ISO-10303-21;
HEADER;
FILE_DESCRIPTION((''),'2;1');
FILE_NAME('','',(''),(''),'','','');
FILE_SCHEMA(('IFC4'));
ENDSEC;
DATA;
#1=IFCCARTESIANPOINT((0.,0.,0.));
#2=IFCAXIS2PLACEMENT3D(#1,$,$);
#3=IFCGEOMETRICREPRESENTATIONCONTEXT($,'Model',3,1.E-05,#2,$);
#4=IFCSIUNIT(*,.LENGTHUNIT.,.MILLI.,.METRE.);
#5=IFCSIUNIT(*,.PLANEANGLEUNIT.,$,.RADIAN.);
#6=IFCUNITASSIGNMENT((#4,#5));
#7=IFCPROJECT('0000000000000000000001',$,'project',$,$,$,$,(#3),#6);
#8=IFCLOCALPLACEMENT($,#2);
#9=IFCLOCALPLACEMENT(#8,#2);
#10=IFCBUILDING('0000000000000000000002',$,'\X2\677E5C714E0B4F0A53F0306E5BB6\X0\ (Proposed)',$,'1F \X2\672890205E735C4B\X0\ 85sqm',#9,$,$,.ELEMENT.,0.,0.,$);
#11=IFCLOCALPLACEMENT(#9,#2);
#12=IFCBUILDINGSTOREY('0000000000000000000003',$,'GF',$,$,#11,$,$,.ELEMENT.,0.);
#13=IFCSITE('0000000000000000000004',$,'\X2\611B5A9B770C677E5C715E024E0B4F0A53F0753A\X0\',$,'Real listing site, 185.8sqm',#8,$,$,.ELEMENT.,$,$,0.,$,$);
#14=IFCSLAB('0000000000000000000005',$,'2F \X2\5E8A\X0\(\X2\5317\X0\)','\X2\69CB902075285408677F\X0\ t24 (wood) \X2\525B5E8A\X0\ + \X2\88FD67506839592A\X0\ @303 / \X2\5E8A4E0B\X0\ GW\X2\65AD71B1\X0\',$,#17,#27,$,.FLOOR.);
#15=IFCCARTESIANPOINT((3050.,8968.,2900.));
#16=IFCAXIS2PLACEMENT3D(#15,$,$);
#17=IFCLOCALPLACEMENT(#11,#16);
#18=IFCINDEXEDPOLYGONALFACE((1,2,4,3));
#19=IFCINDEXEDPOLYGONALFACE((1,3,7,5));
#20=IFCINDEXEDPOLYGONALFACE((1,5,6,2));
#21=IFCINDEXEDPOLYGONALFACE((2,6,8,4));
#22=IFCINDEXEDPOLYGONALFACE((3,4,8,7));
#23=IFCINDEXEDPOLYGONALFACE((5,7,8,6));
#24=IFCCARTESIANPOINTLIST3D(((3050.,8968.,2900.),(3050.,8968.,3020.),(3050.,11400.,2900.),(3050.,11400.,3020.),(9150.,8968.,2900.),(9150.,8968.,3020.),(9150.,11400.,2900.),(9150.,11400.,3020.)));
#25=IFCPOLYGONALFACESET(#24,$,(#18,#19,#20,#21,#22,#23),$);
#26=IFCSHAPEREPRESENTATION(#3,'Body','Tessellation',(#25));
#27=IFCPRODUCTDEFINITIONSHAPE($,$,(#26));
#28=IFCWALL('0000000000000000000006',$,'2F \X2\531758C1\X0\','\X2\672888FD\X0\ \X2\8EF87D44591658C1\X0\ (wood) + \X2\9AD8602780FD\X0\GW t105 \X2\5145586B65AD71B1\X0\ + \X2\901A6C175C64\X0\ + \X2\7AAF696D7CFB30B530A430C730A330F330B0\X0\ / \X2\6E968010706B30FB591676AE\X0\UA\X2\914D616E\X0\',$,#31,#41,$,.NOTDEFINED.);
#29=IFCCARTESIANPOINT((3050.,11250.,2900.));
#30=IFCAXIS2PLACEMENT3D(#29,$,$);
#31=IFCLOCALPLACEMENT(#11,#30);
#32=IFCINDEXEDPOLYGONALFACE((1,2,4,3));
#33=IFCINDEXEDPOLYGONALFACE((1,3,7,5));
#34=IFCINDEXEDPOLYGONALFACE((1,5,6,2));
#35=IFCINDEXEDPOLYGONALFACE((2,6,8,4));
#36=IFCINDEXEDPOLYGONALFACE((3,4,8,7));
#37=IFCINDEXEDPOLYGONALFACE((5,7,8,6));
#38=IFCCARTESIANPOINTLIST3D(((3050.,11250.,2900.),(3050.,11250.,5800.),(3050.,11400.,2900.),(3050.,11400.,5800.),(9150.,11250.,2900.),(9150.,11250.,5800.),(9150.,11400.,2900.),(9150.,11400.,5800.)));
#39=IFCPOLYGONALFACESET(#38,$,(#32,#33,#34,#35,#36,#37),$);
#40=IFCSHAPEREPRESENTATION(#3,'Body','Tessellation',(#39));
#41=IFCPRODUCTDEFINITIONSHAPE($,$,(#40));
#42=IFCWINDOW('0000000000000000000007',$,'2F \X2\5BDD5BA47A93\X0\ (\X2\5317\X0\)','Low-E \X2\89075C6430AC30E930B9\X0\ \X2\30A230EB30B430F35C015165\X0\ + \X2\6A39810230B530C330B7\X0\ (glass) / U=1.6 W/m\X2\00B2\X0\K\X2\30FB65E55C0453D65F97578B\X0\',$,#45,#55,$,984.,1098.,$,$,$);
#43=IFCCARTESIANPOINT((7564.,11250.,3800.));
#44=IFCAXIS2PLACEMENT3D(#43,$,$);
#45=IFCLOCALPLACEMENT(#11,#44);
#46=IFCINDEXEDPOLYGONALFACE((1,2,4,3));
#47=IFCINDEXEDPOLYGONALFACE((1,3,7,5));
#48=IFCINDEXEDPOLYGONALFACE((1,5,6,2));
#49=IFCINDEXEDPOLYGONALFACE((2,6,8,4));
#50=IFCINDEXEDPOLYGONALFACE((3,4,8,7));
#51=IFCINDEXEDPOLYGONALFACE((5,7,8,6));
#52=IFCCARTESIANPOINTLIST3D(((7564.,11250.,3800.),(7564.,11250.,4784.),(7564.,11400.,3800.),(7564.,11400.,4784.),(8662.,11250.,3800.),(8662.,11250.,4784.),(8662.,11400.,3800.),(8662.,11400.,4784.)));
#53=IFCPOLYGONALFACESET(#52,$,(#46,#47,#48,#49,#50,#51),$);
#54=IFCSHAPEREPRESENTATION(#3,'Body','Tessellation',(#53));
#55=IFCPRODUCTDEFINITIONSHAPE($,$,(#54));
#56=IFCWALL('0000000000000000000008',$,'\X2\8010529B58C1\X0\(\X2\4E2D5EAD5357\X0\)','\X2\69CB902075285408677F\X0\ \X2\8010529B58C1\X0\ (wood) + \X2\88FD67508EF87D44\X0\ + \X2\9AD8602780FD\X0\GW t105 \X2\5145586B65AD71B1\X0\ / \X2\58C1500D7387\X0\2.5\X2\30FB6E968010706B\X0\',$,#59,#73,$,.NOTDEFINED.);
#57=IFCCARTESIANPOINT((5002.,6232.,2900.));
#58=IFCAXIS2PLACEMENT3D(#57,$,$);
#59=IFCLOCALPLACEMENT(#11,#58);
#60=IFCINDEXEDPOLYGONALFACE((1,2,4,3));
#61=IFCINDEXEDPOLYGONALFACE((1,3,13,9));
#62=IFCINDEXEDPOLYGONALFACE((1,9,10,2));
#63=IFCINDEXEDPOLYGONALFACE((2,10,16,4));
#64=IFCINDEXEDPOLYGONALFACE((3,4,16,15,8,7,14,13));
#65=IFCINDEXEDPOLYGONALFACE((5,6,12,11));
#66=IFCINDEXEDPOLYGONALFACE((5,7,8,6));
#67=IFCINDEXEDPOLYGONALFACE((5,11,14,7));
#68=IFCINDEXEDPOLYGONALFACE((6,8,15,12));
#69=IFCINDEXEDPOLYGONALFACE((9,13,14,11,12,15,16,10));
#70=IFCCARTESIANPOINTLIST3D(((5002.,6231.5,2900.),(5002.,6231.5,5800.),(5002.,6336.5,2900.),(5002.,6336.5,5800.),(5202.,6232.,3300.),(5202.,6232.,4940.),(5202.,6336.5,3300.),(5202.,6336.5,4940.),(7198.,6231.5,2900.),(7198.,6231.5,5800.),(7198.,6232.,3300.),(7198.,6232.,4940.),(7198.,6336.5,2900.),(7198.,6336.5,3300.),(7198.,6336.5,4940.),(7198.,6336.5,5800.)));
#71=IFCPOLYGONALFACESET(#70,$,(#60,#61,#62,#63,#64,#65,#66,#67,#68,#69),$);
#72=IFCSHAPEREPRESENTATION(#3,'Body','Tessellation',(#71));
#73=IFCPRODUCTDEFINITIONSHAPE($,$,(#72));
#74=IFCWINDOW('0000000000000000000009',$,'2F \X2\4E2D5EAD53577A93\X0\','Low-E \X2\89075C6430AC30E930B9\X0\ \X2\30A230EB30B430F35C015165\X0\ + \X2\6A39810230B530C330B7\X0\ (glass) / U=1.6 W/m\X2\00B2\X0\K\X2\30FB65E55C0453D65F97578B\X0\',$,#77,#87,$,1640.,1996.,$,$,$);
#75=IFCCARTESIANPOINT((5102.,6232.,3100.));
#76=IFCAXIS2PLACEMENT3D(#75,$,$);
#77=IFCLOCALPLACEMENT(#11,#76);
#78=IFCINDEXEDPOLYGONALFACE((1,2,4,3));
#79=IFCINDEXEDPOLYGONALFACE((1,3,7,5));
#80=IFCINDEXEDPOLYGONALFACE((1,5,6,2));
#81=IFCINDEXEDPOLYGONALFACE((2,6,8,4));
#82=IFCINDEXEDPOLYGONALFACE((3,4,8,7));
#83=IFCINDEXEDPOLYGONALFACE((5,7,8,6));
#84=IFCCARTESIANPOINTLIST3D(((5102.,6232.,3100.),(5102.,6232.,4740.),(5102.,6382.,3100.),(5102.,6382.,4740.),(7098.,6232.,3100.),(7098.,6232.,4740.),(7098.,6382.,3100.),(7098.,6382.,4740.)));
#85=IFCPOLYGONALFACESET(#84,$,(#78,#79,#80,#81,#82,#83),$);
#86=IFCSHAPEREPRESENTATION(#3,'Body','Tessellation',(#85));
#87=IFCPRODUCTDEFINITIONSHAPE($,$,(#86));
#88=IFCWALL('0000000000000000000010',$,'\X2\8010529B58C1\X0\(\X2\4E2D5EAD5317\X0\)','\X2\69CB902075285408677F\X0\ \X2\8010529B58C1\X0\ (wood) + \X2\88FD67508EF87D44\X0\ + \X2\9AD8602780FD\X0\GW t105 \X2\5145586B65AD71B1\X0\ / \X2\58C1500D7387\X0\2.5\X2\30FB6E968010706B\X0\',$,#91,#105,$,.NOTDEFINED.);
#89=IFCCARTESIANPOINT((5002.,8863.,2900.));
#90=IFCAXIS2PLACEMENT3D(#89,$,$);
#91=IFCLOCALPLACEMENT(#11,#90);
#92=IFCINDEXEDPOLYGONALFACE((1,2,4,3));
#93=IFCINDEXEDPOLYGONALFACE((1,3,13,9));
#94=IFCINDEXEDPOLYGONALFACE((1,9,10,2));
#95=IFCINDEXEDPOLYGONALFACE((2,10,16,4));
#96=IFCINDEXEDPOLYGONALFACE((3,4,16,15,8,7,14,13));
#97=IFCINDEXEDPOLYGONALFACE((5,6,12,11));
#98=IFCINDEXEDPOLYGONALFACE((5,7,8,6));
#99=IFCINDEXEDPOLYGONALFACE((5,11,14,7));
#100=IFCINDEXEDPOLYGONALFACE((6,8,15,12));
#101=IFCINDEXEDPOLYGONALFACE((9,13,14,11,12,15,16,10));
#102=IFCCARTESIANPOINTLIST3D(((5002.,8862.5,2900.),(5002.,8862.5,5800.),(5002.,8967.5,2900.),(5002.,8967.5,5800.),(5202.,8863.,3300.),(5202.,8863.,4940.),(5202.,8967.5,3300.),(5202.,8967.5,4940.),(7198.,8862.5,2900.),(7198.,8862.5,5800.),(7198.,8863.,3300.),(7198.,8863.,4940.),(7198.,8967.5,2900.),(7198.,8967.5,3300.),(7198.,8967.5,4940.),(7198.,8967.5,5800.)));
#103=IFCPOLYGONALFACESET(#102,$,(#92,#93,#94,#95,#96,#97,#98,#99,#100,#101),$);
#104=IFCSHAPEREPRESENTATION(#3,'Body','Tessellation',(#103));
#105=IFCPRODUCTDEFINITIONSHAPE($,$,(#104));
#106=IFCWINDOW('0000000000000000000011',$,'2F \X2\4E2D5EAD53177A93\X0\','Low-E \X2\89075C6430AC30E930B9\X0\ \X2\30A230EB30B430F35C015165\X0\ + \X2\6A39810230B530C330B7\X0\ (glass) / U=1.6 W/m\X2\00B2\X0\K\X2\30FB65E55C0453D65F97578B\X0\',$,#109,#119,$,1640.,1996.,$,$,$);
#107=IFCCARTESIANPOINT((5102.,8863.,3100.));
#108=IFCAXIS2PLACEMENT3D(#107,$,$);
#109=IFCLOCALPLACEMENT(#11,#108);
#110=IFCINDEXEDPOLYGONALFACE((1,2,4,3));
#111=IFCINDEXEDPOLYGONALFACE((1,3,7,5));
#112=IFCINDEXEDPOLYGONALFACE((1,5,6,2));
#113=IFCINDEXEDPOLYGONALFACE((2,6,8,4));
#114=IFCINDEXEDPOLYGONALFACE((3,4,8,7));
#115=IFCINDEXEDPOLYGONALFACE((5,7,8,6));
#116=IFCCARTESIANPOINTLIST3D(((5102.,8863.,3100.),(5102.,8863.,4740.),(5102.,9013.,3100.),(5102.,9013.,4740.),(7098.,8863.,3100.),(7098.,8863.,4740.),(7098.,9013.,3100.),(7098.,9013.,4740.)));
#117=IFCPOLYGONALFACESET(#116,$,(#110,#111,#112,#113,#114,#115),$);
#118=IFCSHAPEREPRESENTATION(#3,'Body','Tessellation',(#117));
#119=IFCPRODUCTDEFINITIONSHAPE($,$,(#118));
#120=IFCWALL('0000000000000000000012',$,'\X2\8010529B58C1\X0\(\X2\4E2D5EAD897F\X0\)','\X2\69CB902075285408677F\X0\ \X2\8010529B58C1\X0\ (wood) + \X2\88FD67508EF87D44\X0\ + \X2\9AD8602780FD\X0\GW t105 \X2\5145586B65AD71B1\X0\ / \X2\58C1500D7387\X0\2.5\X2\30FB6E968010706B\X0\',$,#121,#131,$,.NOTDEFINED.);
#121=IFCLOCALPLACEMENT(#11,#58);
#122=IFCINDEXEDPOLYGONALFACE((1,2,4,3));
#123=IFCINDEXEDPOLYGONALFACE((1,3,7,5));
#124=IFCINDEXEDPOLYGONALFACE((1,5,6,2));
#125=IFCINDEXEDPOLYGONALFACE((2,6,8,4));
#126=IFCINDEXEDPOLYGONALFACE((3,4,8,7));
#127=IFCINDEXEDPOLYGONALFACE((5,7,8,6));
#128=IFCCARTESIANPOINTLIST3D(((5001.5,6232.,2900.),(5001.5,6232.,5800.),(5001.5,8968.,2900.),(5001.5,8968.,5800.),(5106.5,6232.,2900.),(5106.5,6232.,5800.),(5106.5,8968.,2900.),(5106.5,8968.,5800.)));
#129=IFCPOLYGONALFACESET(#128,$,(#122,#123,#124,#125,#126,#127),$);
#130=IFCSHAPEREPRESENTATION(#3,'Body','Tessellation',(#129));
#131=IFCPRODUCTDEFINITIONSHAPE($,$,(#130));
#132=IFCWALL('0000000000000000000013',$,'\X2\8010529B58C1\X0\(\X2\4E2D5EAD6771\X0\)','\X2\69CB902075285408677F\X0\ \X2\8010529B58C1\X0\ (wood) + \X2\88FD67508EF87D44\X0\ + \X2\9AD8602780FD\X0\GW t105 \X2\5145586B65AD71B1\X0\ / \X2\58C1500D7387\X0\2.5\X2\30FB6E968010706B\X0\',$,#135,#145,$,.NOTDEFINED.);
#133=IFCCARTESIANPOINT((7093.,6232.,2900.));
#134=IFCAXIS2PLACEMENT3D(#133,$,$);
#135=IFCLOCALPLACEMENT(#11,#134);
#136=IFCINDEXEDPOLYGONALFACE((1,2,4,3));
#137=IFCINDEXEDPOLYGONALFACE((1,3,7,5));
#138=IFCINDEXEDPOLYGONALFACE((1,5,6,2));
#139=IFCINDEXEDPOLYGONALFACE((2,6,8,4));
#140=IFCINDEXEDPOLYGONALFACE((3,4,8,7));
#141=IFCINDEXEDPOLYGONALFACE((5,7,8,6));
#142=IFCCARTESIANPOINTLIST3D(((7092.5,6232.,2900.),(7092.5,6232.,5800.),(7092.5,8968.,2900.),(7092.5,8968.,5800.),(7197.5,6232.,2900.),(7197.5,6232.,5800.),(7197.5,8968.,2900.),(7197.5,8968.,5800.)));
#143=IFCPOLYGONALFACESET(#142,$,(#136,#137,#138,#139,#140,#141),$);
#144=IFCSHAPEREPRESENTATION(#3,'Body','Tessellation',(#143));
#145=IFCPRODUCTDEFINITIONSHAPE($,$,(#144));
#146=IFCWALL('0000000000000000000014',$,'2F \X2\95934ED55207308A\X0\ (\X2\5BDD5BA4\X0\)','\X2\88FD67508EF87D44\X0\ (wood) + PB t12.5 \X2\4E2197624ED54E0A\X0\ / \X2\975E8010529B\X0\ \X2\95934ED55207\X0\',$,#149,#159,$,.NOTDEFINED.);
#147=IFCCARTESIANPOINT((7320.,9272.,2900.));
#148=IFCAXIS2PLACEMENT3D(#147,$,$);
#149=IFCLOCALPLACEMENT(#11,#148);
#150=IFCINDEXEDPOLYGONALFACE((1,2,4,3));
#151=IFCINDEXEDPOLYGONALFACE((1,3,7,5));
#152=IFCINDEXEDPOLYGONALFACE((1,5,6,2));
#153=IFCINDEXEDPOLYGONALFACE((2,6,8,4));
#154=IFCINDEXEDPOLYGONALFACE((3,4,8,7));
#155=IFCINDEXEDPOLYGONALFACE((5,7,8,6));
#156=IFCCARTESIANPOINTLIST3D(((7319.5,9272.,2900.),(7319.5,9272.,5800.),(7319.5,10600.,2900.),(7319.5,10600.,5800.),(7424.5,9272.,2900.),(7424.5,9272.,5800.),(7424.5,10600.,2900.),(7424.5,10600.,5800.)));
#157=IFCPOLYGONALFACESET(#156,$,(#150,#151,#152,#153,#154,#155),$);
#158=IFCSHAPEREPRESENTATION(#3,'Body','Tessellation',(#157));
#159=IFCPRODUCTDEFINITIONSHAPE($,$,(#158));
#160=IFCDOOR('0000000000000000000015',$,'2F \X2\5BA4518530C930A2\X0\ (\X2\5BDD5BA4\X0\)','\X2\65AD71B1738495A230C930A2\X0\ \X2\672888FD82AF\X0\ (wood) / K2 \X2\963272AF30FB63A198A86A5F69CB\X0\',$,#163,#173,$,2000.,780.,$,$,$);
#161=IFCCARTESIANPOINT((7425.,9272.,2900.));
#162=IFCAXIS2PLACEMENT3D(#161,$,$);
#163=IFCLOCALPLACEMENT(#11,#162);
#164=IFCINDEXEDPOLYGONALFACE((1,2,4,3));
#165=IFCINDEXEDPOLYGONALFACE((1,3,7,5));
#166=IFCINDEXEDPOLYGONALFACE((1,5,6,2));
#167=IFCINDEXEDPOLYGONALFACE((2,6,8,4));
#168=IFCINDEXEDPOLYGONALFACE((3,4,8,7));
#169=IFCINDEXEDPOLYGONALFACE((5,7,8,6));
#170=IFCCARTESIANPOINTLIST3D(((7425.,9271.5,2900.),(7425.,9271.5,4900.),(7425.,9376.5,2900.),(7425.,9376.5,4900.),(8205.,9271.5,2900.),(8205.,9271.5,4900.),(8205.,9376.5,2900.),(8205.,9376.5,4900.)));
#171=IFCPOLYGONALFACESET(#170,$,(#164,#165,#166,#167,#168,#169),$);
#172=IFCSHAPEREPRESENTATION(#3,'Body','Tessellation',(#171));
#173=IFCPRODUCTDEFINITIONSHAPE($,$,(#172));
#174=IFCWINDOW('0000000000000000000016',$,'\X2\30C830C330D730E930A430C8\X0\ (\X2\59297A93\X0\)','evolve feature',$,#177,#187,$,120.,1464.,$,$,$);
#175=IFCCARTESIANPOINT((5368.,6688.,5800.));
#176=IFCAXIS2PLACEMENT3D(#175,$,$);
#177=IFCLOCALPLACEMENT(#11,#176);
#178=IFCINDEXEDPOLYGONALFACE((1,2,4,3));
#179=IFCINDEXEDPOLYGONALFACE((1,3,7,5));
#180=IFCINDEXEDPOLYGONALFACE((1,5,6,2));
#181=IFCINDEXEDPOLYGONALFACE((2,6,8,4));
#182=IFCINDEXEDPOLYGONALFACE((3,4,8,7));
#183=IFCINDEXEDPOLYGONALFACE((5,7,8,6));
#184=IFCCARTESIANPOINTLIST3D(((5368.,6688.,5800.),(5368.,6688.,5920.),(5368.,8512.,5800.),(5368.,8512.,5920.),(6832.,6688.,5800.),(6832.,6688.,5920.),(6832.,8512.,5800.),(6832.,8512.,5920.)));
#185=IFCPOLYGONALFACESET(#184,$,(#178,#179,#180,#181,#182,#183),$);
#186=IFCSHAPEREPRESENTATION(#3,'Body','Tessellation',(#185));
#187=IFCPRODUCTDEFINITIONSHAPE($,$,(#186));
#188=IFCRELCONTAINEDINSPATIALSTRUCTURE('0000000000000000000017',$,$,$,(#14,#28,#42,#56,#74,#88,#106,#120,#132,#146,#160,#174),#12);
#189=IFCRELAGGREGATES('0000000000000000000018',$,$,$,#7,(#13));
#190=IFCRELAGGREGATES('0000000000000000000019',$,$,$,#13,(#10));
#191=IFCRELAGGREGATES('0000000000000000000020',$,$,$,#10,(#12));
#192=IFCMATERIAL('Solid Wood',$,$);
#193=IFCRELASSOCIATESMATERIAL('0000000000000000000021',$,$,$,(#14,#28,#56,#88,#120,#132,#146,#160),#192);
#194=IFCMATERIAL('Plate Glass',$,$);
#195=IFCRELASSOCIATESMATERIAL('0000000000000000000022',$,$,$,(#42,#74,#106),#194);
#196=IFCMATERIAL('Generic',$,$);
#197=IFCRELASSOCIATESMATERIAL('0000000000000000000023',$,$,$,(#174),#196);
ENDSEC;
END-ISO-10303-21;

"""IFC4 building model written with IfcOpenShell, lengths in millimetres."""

from ifc_helpers import new_model, si_unit, frame, frame_2d, origin, place, context, project, spatial, rectangle, extrude, material, element, fill, save


model = new_model("IFC4")

# Units and contexts
model_context = context("Model", 3, precision=1e-05, world=origin())
ifc_project = project(units=[si_unit("LENGTHUNIT", "METRE", prefix="MILLI"), si_unit("PLANEANGLEUNIT", "RADIAN")], contexts=[model_context])

# Site, building, storey
site_placement = place(None, origin())
site = spatial("IfcSite", under=ifc_project, at=site_placement, Name="愛媛県松山市下伊台町", ObjectType="Real listing site, 185.8sqm", CompositionType="ELEMENT", RefElevation=0.0)
building_placement = place(site_placement, origin())
building = spatial("IfcBuilding", under=site, at=building_placement, Name="松山下伊台の家 (Proposed)", ObjectType="1F 木造平屋 85sqm", CompositionType="ELEMENT", ElevationOfRefHeight=0.0, ElevationOfTerrain=0.0)
storey_placement = place(building_placement, origin())
storey = spatial("IfcBuildingStorey", under=building, at=storey_placement, Name="GF", CompositionType="ELEMENT", Elevation=0.0)

# Slab
ifc_material_1 = material(Name="Solid Wood")
slab_placement = place(storey_placement, frame((3050.0, 8968.0, 2900.0)))
element("IfcSlab", 1, at=slab_placement, inside=storey, material=ifc_material_1, Name="2F 床(北)", Description="構造用合板 t24 (wood) 剛床 + 製材根太 @303 / 床下 GW断熱", PredefinedType="FLOOR", context=model_context, shape_type="SweptSolid", body=[
    extrude(rectangle(XDim=6100.0, YDim=2432.0, at=frame_2d((3050.0, 1216.0))), frame((3050.0, 8968.0, 2900.0)), (0.0, 0.0, 1.0), 120.0),
])

# Walls, openings, windows
wall_1_placement = place(storey_placement, frame((3050.0, 11250.0, 2900.0)))
wall_1 = element("IfcWall", 2, at=wall_1_placement, inside=storey, material=ifc_material_1, Name="2F 北壁", Description="木製 軸組外壁 (wood) + 高性能GW t105 充填断熱 + 通気層 + 窯業系サイディング / 準耐火・外皮UA配慮", PredefinedType="NOTDEFINED", context=model_context, shape_type="SweptSolid", body=[
    extrude(rectangle(XDim=6100.0, YDim=150.0, at=frame_2d((3050.0, 75.0))), frame((3050.0, 11250.0, 2900.0)), (0.0, 0.0, 1.0), 2900.0),
])
opening_1_placement = place(storey_placement, frame((7564.0, 11250.0, 3800.0)))
opening_1 = element("IfcOpeningElement", 3, at=opening_1_placement, cuts=wall_1, PredefinedType="NOTDEFINED", context=model_context, shape_type="SweptSolid", body=[
    extrude(rectangle(XDim=1098.0, YDim=150.0, at=frame_2d((549.0, 75.0))), frame((7564.0, 11250.0, 3800.0)), (0.0, 0.0, 1.0), 984.0),
])
ifc_material_2 = material(Name="Plate Glass")
window_1_placement = place(storey_placement, frame((7564.0, 11250.0, 3800.0)))
window_1 = element("IfcWindow", 4, at=window_1_placement, inside=storey, material=ifc_material_2, Name="2F 寝室窓 (北)", Description="Low-E 複層ガラス アルゴン封入 + 樹脂サッシ (glass) / U=1.6 W/m²K・日射取得型", OverallHeight=984.0, OverallWidth=1098.0, context=model_context, shape_type="SweptSolid", body=[
    extrude(rectangle(XDim=1098.0, YDim=150.0, at=frame_2d((549.0, 75.0))), frame((7564.0, 11250.0, 3800.0)), (0.0, 0.0, 1.0), 984.0),
])
fill(opening_1, window_1)
wall_2_placement = place(storey_placement, frame((5002.0, 6232.0, 2900.0)))
wall_2 = element("IfcWall", 5, at=wall_2_placement, inside=storey, material=ifc_material_1, Name="耐力壁(中庭南)", Description="構造用合板 耐力壁 (wood) + 製材軸組 + 高性能GW t105 充填断熱 / 壁倍率2.5・準耐火", PredefinedType="NOTDEFINED", context=model_context, shape_type="SweptSolid", body=[
    extrude(rectangle(XDim=2196.0, YDim=105.0, at=frame_2d((1098.0, 52.0))), frame((5002.0, 6232.0, 2900.0)), (0.0, 0.0, 1.0), 2900.0),
])
opening_2_placement = place(storey_placement, frame((5102.0, 6232.0, 3100.0)))
opening_2 = element("IfcOpeningElement", 6, at=opening_2_placement, cuts=wall_2, PredefinedType="NOTDEFINED", context=model_context, shape_type="SweptSolid", body=[
    extrude(rectangle(XDim=1996.0, YDim=150.0, at=frame_2d((998.0, 75.0))), frame((5102.0, 6232.0, 3100.0)), (0.0, 0.0, 1.0), 1640.0),
])
window_2_placement = place(storey_placement, frame((5102.0, 6232.0, 3100.0)))
window_2 = element("IfcWindow", 7, at=window_2_placement, inside=storey, material=ifc_material_2, Name="2F 中庭南窓", Description="Low-E 複層ガラス アルゴン封入 + 樹脂サッシ (glass) / U=1.6 W/m²K・日射取得型", OverallHeight=1640.0, OverallWidth=1996.0, context=model_context, shape_type="SweptSolid", body=[
    extrude(rectangle(XDim=1996.0, YDim=150.0, at=frame_2d((998.0, 75.0))), frame((5102.0, 6232.0, 3100.0)), (0.0, 0.0, 1.0), 1640.0),
])
fill(opening_2, window_2)
wall_3_placement = place(storey_placement, frame((5002.0, 8863.0, 2900.0)))
wall_3 = element("IfcWall", 8, at=wall_3_placement, inside=storey, material=ifc_material_1, Name="耐力壁(中庭北)", Description="構造用合板 耐力壁 (wood) + 製材軸組 + 高性能GW t105 充填断熱 / 壁倍率2.5・準耐火", PredefinedType="NOTDEFINED", context=model_context, shape_type="SweptSolid", body=[
    extrude(rectangle(XDim=2196.0, YDim=105.0, at=frame_2d((1098.0, 52.0))), frame((5002.0, 8863.0, 2900.0)), (0.0, 0.0, 1.0), 2900.0),
])
opening_3_placement = place(storey_placement, frame((5102.0, 8863.0, 3100.0)))
opening_3 = element("IfcOpeningElement", 9, at=opening_3_placement, cuts=wall_3, PredefinedType="NOTDEFINED", context=model_context, shape_type="SweptSolid", body=[
    extrude(rectangle(XDim=1996.0, YDim=150.0, at=frame_2d((998.0, 75.0))), frame((5102.0, 8863.0, 3100.0)), (0.0, 0.0, 1.0), 1640.0),
])
window_3_placement = place(storey_placement, frame((5102.0, 8863.0, 3100.0)))
window_3 = element("IfcWindow", 10, at=window_3_placement, inside=storey, material=ifc_material_2, Name="2F 中庭北窓", Description="Low-E 複層ガラス アルゴン封入 + 樹脂サッシ (glass) / U=1.6 W/m²K・日射取得型", OverallHeight=1640.0, OverallWidth=1996.0, context=model_context, shape_type="SweptSolid", body=[
    extrude(rectangle(XDim=1996.0, YDim=150.0, at=frame_2d((998.0, 75.0))), frame((5102.0, 8863.0, 3100.0)), (0.0, 0.0, 1.0), 1640.0),
])
fill(opening_3, window_3)

# Walls
wall_4_placement = place(storey_placement, frame((5002.0, 6232.0, 2900.0)))
element("IfcWall", 11, at=wall_4_placement, inside=storey, material=ifc_material_1, Name="耐力壁(中庭西)", Description="構造用合板 耐力壁 (wood) + 製材軸組 + 高性能GW t105 充填断熱 / 壁倍率2.5・準耐火", PredefinedType="NOTDEFINED", context=model_context, shape_type="SweptSolid", body=[
    extrude(rectangle(XDim=105.0, YDim=2736.0, at=frame_2d((52.0, 1368.0))), frame((5002.0, 6232.0, 2900.0)), (0.0, 0.0, 1.0), 2900.0),
])
wall_5_placement = place(storey_placement, frame((7093.0, 6232.0, 2900.0)))
element("IfcWall", 12, at=wall_5_placement, inside=storey, material=ifc_material_1, Name="耐力壁(中庭東)", Description="構造用合板 耐力壁 (wood) + 製材軸組 + 高性能GW t105 充填断熱 / 壁倍率2.5・準耐火", PredefinedType="NOTDEFINED", context=model_context, shape_type="SweptSolid", body=[
    extrude(rectangle(XDim=105.0, YDim=2736.0, at=frame_2d((52.0, 1368.0))), frame((7093.0, 6232.0, 2900.0)), (0.0, 0.0, 1.0), 2900.0),
])
wall_6_placement = place(storey_placement, frame((7320.0, 9272.0, 2900.0)))
element("IfcWall", 13, at=wall_6_placement, inside=storey, material=ifc_material_1, Name="2F 間仕切り (寝室)", Description="製材軸組 (wood) + PB t12.5 両面仕上 / 非耐力 間仕切", PredefinedType="NOTDEFINED", context=model_context, shape_type="SweptSolid", body=[
    extrude(rectangle(XDim=105.0, YDim=1328.0, at=frame_2d((52.0, 664.0))), frame((7320.0, 9272.0, 2900.0)), (0.0, 0.0, 1.0), 2900.0),
])

# Door
door_placement = place(storey_placement, frame((7425.0, 9272.0, 2900.0)))
element("IfcDoor", 14, at=door_placement, inside=storey, material=ifc_material_1, Name="2F 室内ドア (寝室)", Description="断熱玄関ドア 木製芯 (wood) / K2 防犯・採風機構", OverallHeight=2000.0, OverallWidth=780.0, context=model_context, shape_type="SweptSolid", body=[
    extrude(rectangle(XDim=780.0, YDim=105.0, at=frame_2d((390.0, 52.0))), frame((7425.0, 9272.0, 2900.0)), (0.0, 0.0, 1.0), 2000.0),
])

# Window
ifc_material_3 = material(Name="Generic")
window_4_placement = place(storey_placement, frame((5368.0, 6688.0, 5800.0)))
element("IfcWindow", 15, at=window_4_placement, inside=storey, material=ifc_material_3, Name="トップライト (天窓)", Description="evolve feature", OverallHeight=120.0, OverallWidth=1464.0, context=model_context, shape_type="SweptSolid", body=[
    extrude(rectangle(XDim=1464.0, YDim=1824.0, at=frame_2d((732.0, 912.0))), frame((5368.0, 6688.0, 5800.0)), (0.0, 0.0, 1.0), 120.0),
])

save(model, "model.ifc")
